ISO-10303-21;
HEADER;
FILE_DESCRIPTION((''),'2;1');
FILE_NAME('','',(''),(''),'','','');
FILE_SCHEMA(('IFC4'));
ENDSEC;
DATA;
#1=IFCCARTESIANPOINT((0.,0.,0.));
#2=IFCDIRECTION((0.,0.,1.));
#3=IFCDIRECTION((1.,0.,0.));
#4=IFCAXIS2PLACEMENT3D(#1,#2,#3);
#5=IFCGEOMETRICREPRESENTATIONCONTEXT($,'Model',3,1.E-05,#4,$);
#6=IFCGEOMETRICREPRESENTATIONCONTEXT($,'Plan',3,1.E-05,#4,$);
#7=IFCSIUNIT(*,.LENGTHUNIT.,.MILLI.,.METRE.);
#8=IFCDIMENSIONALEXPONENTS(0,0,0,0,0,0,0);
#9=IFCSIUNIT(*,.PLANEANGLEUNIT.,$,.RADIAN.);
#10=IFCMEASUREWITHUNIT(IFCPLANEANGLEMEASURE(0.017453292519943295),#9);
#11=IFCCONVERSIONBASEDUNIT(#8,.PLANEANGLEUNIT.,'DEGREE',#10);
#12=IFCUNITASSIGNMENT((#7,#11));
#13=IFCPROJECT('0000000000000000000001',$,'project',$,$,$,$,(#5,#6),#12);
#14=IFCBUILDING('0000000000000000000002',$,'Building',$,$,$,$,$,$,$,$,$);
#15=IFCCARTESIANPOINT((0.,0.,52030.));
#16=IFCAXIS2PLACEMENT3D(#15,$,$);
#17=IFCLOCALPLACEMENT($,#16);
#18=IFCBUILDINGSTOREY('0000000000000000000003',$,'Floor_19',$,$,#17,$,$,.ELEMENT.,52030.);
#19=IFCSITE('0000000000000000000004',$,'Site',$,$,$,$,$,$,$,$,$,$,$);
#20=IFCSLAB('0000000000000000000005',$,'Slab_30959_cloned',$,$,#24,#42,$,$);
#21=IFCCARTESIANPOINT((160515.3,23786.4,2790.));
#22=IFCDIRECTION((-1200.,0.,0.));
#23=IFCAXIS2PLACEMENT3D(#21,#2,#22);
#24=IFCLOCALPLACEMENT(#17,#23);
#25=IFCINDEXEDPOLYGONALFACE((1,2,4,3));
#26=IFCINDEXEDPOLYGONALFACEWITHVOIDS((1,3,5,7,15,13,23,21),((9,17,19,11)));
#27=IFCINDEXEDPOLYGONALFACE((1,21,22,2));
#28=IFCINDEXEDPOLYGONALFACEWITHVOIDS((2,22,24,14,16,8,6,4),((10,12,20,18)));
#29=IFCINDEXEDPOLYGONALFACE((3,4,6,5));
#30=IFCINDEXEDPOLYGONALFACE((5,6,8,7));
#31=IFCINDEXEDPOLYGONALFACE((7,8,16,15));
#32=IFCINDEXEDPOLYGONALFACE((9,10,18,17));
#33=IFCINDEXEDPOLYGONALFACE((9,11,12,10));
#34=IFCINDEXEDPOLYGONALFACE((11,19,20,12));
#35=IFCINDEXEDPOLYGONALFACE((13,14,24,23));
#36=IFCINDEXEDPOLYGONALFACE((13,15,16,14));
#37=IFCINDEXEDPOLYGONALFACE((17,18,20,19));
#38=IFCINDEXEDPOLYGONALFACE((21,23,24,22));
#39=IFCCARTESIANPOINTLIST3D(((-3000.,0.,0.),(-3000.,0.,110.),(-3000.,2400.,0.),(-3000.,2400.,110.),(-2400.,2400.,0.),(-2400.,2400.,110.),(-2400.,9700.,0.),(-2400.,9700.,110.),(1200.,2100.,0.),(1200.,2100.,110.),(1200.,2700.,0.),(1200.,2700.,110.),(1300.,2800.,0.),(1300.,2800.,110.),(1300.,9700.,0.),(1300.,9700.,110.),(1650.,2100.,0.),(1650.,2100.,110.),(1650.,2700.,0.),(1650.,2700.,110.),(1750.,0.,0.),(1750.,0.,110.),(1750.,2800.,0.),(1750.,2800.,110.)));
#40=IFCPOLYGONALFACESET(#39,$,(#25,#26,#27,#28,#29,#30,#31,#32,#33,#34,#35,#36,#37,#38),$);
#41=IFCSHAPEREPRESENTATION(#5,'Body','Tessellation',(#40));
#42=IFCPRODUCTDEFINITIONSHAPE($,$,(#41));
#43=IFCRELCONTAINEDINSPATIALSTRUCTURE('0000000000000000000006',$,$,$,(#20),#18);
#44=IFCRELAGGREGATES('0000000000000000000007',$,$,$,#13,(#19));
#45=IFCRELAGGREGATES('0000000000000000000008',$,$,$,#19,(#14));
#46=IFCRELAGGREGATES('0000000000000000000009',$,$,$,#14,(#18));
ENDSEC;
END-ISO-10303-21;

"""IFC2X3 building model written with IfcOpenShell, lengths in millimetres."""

from ifc_helpers import new_model, entity, si_unit, converted_unit, frame, origin_with_axes, origin_2d, place, context, project, spatial, polyline, rectangle, outline, extrude, source, transform, mapped, element, save


model = new_model("IFC2X3")

# Units and contexts
model_context = context("Model", 3, precision=1e-05, world=origin_with_axes())
plan_context = context("Plan", 3, precision=1e-05, world=origin_with_axes())
ifc_project = project(units=[si_unit("LENGTHUNIT", "METRE", prefix="MILLI"), converted_unit("PLANEANGLEUNIT", "DEGREE", entity("IfcPlaneAngleMeasure", 0.017453292519943295), si_unit("PLANEANGLEUNIT", "RADIAN"), dimensions=[0, 0, 0, 0, 0, 0, 0])], contexts=[model_context, plan_context])

# Site, building, storey
site = spatial("IfcSite", under=ifc_project, Name="Site")
building = spatial("IfcBuilding", under=site, Name="Building")
storey_placement = place(None, frame((0.0, 0.0, 52030.0)))
storey = spatial("IfcBuildingStorey", under=building, at=storey_placement, Name="Floor_19", CompositionType="ELEMENT", Elevation=52030.0)

# Slab, opening
shared_shape_1 = source(origin_with_axes(), model_context, "Body", "SweptSolid", [
    extrude(outline(polyline([(0.0, 0.0), (1200.0, 0.0), (1750.0, 0.0), (1750.0, 1800.0), (1750.0, 2800.0), (1300.0, 2800.0), (1300.0, 5100.0), (1300.0, 9700.0), (-1500.0, 9700.0), (-2400.0, 9700.0), (-2400.0, 7800.0), (-2400.0, 4400.0), (-2400.0, 2400.0), (-3000.0, 2400.0), (-3000.0, 0.0), (-700.0, 0.0)])), origin_with_axes(), (0.0, 0.0, 1.0), 110.0),
])
slab_1_placement = place(storey_placement, frame((160515.3, 23786.4, 2790.0), z_axis=(0.0, 0.0, 1.0), x_axis=(-1200.0, 0.0, 0.0)))
slab_1 = element("IfcSlab", 1, at=slab_1_placement, inside=storey, Name="Slab_30959_cloned", context=model_context, shape_type="MappedRepresentation", body=[
    mapped(shared_shape_1, transform((0.0, 0.0, 0.0), x_axis=(1.0, 0.0, 0.0), y_axis=(0.0, 1.0, 0.0), z_axis=(0.0, 0.0, 1.0), scale=1.0)),
])
shared_shape_2 = source(origin_with_axes(), model_context, "Body", "SweptSolid", [
    extrude(rectangle(XDim=450.0, YDim=600.0, at=origin_2d()), origin_with_axes(), (0.0, 0.0, 1.0), 10000.0),
])
opening_placement = place(storey_placement, frame((159090.3, 21386.4, 0.0), z_axis=(0.0, 0.0, 1.0), x_axis=(225.0, 0.0, 0.0)))
element("IfcOpeningElement", 2, at=opening_placement, inside=storey, cuts=slab_1, context=model_context, shape_type="MappedRepresentation", body=[
    mapped(shared_shape_2, transform((0.0, 0.0, 0.0), x_axis=(1.0, 0.0, 0.0), y_axis=(0.0, 1.0, 0.0), z_axis=(0.0, 0.0, 1.0), scale=1.0)),
])

save(model, "model.ifc")
